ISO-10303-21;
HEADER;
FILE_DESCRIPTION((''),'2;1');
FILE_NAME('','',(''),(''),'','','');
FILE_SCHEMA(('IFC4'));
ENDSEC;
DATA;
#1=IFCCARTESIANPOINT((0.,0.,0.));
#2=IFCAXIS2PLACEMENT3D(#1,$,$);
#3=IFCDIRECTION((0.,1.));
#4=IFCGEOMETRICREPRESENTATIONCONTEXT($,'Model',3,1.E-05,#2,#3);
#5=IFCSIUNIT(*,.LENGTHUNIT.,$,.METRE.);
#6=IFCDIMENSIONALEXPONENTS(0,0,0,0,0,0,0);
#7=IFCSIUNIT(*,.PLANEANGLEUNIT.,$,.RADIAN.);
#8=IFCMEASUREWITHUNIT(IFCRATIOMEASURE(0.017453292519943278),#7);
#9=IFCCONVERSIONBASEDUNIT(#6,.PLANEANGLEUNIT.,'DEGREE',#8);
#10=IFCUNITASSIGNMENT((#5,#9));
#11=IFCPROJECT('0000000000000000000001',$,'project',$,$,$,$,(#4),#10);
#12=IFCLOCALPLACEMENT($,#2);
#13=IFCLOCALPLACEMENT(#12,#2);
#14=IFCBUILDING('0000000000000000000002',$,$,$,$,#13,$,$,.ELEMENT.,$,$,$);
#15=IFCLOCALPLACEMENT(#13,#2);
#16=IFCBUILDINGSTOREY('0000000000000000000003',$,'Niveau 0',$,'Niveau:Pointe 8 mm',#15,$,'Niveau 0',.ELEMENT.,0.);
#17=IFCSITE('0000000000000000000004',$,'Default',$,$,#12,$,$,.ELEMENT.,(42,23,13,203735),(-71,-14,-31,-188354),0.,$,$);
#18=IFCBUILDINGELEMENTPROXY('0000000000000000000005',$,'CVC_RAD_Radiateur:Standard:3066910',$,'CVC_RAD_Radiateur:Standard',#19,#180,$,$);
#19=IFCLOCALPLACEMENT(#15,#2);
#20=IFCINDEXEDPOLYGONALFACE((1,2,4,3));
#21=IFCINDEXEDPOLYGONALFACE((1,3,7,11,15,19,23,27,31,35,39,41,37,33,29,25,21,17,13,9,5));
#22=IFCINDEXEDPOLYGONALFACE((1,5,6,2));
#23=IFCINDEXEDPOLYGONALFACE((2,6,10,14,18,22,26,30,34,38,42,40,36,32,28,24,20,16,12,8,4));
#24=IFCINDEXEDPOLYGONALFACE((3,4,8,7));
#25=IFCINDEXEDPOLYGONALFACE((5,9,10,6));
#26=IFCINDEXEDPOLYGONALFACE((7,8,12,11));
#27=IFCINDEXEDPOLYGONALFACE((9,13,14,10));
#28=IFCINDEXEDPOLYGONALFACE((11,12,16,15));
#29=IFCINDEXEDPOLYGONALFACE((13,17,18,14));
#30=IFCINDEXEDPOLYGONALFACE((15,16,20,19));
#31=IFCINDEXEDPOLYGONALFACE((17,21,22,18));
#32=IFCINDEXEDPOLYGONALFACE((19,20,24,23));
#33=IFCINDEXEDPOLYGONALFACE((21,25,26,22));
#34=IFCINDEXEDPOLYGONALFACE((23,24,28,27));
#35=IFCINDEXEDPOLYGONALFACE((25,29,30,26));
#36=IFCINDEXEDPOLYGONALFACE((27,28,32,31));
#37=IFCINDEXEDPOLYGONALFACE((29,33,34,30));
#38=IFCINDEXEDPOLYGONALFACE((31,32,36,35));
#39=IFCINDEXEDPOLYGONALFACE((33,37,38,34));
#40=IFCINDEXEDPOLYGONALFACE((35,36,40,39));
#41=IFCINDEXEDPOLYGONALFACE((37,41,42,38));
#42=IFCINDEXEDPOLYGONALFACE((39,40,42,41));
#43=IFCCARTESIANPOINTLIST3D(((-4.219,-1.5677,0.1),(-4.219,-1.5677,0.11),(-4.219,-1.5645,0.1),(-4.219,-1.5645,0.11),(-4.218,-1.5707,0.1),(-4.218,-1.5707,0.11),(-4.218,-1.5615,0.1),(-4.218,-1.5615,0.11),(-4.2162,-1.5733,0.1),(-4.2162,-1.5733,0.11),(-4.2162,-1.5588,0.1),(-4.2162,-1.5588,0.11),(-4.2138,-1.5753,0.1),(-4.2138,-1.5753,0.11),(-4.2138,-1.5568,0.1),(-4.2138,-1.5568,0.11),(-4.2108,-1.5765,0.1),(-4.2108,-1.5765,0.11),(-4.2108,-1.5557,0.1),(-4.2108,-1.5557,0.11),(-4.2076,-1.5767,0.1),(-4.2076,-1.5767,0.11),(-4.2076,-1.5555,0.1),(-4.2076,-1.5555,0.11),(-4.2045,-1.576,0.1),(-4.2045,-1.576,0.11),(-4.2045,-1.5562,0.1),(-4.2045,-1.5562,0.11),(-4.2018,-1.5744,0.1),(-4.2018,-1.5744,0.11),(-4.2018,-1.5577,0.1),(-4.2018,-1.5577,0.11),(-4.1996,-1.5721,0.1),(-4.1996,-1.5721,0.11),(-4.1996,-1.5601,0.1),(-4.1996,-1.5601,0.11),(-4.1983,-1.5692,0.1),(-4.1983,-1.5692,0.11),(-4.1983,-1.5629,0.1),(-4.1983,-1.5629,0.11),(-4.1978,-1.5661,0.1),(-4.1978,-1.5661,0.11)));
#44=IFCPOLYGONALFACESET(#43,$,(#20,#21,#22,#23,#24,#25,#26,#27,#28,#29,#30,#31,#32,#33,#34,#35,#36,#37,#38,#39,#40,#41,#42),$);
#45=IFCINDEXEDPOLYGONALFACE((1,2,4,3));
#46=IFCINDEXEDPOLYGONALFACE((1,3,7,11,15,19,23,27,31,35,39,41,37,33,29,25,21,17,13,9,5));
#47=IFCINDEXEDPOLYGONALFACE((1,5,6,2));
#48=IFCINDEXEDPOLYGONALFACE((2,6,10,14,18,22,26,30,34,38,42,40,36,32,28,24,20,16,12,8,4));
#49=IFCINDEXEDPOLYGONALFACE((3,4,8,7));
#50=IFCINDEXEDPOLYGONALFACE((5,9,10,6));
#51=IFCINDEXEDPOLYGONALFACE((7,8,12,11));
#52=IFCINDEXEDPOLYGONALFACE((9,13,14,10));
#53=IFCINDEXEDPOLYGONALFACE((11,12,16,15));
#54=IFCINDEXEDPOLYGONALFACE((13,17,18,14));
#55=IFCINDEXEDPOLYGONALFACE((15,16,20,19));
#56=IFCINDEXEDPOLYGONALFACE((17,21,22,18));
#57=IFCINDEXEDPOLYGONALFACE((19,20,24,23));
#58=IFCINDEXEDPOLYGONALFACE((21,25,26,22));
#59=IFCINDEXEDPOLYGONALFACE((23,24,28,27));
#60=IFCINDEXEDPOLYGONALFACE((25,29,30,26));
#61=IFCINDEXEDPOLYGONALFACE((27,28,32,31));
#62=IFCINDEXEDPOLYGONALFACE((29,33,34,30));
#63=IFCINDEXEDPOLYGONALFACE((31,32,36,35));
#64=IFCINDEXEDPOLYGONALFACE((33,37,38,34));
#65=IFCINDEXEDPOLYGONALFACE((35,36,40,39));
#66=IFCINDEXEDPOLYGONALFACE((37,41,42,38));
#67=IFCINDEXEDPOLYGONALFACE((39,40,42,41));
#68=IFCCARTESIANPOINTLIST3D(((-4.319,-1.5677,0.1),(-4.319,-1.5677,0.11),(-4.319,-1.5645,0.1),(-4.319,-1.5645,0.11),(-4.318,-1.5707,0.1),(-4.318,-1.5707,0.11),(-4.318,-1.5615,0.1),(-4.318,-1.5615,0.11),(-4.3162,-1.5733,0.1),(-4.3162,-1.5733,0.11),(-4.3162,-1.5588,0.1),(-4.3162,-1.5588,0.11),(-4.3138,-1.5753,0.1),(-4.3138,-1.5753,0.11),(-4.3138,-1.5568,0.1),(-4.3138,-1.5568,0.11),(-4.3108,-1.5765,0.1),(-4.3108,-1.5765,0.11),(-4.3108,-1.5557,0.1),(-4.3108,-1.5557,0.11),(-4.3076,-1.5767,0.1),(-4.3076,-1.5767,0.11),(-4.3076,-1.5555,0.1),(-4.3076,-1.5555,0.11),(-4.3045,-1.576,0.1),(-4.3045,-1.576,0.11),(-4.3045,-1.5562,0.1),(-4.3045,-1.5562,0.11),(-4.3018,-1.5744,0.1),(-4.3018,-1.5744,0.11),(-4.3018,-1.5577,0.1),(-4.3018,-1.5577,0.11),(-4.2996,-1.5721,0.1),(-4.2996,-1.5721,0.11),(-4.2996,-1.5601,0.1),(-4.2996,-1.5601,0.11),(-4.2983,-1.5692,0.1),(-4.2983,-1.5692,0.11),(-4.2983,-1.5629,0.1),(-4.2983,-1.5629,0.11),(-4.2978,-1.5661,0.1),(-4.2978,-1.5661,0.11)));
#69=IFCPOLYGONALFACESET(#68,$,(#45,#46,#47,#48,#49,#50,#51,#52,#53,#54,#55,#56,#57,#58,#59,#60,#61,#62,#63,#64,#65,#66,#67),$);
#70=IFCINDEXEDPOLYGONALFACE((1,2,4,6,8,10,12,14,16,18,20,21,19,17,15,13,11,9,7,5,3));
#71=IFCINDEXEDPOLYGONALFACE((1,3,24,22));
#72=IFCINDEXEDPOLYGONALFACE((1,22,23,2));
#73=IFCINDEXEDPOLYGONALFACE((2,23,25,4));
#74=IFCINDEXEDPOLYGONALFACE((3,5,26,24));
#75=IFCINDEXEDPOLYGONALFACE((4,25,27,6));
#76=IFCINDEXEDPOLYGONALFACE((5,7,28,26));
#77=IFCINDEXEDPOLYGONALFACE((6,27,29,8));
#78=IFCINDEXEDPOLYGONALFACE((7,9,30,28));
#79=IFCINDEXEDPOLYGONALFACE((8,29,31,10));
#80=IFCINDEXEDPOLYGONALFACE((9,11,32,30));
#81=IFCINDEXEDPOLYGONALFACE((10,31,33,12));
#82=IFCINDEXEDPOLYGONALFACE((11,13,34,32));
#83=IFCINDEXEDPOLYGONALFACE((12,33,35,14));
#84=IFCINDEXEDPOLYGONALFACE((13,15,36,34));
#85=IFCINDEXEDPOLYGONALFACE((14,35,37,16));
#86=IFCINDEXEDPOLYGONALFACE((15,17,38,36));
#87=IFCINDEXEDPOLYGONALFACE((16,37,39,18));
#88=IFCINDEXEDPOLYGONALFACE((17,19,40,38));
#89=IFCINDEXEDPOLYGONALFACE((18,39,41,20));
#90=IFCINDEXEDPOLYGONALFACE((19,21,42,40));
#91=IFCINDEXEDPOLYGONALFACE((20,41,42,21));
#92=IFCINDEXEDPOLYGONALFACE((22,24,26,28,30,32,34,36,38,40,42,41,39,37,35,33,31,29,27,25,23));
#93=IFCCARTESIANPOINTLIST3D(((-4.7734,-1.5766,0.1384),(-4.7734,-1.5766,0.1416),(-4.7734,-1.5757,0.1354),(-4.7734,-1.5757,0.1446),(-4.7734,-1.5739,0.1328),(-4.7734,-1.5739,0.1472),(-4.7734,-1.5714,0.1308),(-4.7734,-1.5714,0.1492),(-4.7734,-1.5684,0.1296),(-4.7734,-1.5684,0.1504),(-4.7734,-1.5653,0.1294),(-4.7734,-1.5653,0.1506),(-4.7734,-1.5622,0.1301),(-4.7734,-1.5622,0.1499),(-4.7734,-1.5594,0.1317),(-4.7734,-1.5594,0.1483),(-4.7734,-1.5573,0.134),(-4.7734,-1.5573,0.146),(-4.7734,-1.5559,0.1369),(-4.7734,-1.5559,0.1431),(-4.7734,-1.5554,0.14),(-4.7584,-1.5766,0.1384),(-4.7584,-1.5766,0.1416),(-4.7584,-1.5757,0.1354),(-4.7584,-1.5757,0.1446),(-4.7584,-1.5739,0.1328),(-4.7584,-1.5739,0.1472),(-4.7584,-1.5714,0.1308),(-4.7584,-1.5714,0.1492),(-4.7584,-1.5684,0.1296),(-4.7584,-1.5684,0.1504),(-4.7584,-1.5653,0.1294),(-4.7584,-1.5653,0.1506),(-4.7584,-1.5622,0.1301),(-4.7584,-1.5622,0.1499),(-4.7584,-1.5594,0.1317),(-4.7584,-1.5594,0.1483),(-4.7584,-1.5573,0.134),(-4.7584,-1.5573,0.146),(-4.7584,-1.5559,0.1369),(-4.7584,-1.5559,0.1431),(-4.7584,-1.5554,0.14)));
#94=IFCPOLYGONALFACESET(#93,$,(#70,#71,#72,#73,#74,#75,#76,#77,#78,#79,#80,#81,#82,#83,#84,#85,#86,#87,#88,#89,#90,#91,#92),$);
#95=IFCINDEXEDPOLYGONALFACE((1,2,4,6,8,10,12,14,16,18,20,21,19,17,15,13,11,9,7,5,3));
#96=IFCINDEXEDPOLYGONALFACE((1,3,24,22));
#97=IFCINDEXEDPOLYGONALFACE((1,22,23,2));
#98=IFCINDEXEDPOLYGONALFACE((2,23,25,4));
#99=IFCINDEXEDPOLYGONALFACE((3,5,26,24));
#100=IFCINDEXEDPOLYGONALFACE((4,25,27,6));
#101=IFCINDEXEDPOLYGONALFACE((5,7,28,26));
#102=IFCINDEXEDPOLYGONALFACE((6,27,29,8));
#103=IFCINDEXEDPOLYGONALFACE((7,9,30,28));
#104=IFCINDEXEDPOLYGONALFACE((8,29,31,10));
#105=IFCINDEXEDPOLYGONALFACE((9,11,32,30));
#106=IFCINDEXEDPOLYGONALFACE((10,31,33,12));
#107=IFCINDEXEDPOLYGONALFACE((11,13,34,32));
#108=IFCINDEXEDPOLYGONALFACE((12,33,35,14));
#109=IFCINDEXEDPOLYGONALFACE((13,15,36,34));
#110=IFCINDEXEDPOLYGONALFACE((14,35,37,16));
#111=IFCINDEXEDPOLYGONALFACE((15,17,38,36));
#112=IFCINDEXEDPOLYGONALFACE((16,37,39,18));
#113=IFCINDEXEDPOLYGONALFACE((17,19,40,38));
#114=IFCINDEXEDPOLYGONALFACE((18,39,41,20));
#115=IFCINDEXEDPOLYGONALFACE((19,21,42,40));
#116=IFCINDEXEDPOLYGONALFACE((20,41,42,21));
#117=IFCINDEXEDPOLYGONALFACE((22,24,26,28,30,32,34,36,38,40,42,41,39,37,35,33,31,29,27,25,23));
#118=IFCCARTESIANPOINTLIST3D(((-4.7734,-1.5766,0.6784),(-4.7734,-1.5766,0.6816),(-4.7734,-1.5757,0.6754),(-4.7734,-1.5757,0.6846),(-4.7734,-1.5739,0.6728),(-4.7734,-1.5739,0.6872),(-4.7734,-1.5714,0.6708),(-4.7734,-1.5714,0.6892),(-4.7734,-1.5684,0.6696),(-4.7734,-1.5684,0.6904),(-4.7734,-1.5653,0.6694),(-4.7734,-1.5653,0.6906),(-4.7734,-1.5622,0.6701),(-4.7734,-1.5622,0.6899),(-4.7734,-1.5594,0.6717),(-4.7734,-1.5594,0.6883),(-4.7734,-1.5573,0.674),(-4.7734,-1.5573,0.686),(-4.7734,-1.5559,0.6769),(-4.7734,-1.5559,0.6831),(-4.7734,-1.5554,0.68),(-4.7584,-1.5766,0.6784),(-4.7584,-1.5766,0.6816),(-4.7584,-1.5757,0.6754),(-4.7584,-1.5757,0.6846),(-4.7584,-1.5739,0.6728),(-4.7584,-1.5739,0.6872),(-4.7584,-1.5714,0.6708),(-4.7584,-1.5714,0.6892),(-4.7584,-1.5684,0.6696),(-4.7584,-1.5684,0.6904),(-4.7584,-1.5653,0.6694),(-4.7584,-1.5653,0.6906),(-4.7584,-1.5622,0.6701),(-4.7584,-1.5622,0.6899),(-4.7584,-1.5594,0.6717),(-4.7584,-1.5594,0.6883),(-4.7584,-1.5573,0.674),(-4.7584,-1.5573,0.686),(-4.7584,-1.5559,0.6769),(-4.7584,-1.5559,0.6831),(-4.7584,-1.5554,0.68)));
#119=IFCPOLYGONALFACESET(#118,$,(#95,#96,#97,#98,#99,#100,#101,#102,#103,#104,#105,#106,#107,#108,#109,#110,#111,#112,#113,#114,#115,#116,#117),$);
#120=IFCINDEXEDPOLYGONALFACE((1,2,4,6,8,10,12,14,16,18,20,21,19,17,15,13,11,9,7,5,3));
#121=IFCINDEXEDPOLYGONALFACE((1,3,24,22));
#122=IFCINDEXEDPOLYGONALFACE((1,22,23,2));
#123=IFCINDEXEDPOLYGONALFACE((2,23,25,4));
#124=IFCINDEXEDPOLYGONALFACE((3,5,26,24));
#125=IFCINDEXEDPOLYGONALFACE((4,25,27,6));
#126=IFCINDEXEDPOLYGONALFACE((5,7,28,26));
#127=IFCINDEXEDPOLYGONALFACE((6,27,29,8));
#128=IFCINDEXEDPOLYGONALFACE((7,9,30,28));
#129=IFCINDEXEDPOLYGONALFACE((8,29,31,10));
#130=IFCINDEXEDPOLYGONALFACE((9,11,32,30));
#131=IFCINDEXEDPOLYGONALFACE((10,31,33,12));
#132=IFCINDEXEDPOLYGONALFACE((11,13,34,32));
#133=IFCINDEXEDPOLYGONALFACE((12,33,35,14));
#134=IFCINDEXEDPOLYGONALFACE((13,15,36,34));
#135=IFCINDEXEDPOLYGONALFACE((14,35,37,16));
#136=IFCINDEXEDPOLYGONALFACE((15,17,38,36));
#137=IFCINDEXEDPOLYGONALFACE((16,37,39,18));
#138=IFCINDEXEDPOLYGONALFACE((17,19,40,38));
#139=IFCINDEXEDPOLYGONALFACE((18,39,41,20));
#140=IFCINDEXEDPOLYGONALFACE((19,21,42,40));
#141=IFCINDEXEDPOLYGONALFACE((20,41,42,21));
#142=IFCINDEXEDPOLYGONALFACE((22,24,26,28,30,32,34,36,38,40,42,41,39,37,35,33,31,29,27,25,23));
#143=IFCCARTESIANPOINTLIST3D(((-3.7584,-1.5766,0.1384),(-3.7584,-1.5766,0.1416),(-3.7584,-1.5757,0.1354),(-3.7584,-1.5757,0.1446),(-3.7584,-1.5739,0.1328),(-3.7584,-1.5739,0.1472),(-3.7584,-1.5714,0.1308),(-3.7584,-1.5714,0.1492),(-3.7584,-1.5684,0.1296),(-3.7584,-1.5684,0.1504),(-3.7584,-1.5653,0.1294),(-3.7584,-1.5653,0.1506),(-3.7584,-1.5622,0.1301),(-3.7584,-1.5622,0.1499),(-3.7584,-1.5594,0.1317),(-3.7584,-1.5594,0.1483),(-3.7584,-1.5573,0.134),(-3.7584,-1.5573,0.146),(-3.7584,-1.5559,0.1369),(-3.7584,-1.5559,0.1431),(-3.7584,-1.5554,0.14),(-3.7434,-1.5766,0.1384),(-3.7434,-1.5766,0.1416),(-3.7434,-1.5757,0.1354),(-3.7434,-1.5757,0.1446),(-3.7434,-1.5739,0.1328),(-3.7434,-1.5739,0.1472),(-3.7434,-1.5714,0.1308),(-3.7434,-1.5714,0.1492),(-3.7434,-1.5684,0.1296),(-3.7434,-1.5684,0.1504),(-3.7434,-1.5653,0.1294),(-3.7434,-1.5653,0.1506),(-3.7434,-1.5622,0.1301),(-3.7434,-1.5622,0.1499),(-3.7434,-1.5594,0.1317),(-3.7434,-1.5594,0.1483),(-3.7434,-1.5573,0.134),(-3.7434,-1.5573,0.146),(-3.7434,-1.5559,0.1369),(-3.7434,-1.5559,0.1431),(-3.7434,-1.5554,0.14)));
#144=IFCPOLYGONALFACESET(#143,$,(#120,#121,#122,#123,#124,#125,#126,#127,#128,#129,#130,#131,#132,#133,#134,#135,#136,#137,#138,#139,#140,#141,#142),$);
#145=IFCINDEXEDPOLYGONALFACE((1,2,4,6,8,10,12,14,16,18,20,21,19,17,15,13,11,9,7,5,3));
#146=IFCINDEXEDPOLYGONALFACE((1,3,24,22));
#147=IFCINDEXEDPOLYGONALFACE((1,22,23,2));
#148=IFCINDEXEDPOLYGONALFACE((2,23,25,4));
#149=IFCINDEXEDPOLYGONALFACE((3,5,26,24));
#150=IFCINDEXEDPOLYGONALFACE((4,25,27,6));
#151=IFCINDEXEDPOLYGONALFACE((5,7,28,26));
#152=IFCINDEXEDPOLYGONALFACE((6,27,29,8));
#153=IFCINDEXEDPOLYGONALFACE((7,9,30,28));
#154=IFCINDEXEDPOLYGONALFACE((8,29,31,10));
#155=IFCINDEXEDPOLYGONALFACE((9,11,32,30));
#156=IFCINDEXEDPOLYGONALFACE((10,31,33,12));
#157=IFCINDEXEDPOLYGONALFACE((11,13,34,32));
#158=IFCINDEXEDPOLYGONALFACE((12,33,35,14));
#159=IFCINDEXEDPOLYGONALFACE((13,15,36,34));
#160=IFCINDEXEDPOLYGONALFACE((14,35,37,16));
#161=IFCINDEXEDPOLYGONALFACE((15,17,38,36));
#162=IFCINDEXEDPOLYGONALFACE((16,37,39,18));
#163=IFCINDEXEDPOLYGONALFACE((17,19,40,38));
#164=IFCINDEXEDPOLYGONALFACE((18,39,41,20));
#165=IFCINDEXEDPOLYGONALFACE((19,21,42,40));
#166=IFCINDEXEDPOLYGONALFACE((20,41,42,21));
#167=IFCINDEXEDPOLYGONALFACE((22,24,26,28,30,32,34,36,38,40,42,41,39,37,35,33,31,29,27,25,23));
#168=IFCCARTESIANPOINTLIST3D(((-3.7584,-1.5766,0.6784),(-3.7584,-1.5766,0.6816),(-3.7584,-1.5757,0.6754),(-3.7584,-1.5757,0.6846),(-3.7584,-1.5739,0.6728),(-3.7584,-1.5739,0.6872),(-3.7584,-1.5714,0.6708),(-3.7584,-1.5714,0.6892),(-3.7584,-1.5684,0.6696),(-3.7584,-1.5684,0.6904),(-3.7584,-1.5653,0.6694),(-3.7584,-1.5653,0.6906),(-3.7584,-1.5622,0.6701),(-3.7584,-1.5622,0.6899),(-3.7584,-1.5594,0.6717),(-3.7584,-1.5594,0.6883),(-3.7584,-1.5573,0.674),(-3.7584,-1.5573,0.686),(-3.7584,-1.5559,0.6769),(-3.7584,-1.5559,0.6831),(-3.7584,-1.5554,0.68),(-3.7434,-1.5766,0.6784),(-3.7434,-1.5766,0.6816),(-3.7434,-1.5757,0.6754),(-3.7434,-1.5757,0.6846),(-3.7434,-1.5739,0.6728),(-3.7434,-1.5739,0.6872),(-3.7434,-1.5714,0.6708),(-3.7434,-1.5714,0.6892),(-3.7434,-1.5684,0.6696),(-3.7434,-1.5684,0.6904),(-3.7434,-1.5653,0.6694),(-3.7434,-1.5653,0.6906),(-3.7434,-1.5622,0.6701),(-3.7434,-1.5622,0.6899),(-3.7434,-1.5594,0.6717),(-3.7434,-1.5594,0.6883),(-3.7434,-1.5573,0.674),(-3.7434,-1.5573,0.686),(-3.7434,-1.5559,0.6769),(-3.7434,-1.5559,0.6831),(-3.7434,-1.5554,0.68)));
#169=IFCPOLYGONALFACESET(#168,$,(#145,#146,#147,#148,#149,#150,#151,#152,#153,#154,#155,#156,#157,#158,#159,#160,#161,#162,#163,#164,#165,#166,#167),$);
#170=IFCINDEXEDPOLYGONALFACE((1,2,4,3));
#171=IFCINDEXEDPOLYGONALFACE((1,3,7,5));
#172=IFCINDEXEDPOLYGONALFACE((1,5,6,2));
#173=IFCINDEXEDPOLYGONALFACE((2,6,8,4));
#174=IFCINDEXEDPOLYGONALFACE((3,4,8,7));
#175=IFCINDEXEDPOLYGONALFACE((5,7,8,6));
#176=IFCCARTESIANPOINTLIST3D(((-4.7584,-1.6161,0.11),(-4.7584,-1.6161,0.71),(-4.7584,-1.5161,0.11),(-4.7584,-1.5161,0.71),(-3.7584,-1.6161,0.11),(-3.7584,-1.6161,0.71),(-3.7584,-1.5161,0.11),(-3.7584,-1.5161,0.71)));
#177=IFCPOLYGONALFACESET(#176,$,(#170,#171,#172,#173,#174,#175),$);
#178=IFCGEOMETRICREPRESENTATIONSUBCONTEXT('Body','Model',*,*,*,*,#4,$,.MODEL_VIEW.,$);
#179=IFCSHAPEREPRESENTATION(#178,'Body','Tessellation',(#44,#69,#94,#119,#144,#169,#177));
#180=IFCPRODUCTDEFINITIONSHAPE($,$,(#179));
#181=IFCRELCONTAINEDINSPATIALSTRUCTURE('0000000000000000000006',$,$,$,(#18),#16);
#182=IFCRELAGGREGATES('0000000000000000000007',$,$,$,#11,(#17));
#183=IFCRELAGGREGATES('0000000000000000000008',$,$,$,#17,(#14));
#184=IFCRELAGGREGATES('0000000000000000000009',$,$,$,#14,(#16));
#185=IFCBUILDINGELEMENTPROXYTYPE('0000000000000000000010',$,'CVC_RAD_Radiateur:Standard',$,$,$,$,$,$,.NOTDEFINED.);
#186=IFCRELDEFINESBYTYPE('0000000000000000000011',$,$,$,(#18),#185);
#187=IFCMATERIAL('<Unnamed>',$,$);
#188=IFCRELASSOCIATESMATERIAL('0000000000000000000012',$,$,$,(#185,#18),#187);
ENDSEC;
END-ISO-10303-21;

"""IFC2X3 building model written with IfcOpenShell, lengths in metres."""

from ifc_helpers import new_model, entity, si_unit, converted_unit, direction, frame, frame_2d, origin, origin_2d_with_axis, place, context, subcontext, project, spatial, rectangle, circle, extrude, source, transform, mapped, material, type_object, type_shapes, element, save


model = new_model("IFC2X3")

# Units and contexts
model_context = context("Model", 3, precision=1e-05, world=origin(), true_north=direction((0.0, 1.0)))
body_context = subcontext(model_context, "Body", "Model", "MODEL_VIEW")
ifc_project = project(units=[si_unit("LENGTHUNIT", "METRE"), converted_unit("PLANEANGLEUNIT", "DEGREE", entity("IfcRatioMeasure", 0.017453292519943278), si_unit("PLANEANGLEUNIT", "RADIAN"), dimensions=[0, 0, 0, 0, 0, 0, 0])], contexts=[model_context])

# Site, building, storey
site_placement = place(None, origin())
site = spatial("IfcSite", under=ifc_project, at=site_placement, Name="Default", CompositionType="ELEMENT", RefLatitude=(42, 23, 13, 203735), RefLongitude=(-71, -14, -31, -188354), RefElevation=0.0)
building_placement = place(site_placement, origin())
building = spatial("IfcBuilding", under=site, at=building_placement, CompositionType="ELEMENT")
storey_placement = place(building_placement, origin())
storey = spatial("IfcBuildingStorey", under=building, at=storey_placement, Name="Niveau 0", ObjectType="Niveau:Pointe 8 mm", LongName="Niveau 0", CompositionType="ELEMENT", Elevation=0.0)

# Building element proxy
ifc_material = material(Name="<Unnamed>")
building_element_proxy_type = type_object("IfcBuildingElementProxyType", Name="CVC_RAD_Radiateur:Standard", PredefinedType="NOTDEFINED", material=ifc_material)
shared_shape = source(origin(), body_context, "Body", "SweptSolid", [
    extrude(circle(Radius=0.0107, at=frame_2d((0.0, 0.0), x_axis=(1.0, 0.0))), frame((0.05, 0.055, 0.0)), (0.0, 0.0, 1.0), 0.01),
    extrude(circle(Radius=0.0107, at=frame_2d((0.0, 0.0), x_axis=(1.0, 0.0))), frame((-0.05, 0.055, 0.0)), (0.0, 0.0, 1.0), 0.01),
    extrude(circle(Radius=0.0107, at=frame_2d((0.0, 0.0), x_axis=(1.0, 0.0))), frame((-0.515, 0.055, 0.04), z_axis=(1.0, 0.0, 0.0), x_axis=(0.0, 1.0, 0.0)), (0.0, 0.0, 1.0), 0.015),
    extrude(circle(Radius=0.0107, at=frame_2d((0.0, 0.0), x_axis=(1.0, 0.0))), frame((-0.515, 0.055, 0.58), z_axis=(1.0, 0.0, 0.0), x_axis=(0.0, 1.0, 0.0)), (0.0, 0.0, 1.0), 0.015),
    extrude(circle(Radius=0.0107, at=frame_2d((0.0, 0.0), x_axis=(1.0, 0.0))), frame((0.5, 0.055, 0.04), z_axis=(1.0, 0.0, 0.0), x_axis=(0.0, 1.0, 0.0)), (0.0, 0.0, 1.0), 0.015),
    extrude(circle(Radius=0.0107, at=origin_2d_with_axis()), frame((0.5, 0.055, 0.58), z_axis=(1.0, 0.0, 0.0), x_axis=(0.0, 1.0, 0.0)), (0.0, 0.0, 1.0), 0.015),
    extrude(rectangle(XDim=1.0, YDim=0.1, at=origin_2d_with_axis()), frame((0.0, 0.055, 0.01), z_axis=(0.0, 0.0, 1.0), x_axis=(-1.0, 0.0, 0.0)), (0.0, 0.0, 1.0), 0.6),
])
type_shapes(building_element_proxy_type, [shared_shape])
proxy_1_placement = place(storey_placement, frame((-4.2584, -1.6211, 0.1)))
element("IfcBuildingElementProxy", 1, at=proxy_1_placement, inside=storey, type_object=building_element_proxy_type, material=ifc_material, Name="CVC_RAD_Radiateur:Standard:3066910", ObjectType="CVC_RAD_Radiateur:Standard", context=body_context, shape_type="MappedRepresentation", body=[
    mapped(shared_shape, transform((0.0, 0.0, 0.0), scale=1.0)),
])

save(model, "model.ifc")
